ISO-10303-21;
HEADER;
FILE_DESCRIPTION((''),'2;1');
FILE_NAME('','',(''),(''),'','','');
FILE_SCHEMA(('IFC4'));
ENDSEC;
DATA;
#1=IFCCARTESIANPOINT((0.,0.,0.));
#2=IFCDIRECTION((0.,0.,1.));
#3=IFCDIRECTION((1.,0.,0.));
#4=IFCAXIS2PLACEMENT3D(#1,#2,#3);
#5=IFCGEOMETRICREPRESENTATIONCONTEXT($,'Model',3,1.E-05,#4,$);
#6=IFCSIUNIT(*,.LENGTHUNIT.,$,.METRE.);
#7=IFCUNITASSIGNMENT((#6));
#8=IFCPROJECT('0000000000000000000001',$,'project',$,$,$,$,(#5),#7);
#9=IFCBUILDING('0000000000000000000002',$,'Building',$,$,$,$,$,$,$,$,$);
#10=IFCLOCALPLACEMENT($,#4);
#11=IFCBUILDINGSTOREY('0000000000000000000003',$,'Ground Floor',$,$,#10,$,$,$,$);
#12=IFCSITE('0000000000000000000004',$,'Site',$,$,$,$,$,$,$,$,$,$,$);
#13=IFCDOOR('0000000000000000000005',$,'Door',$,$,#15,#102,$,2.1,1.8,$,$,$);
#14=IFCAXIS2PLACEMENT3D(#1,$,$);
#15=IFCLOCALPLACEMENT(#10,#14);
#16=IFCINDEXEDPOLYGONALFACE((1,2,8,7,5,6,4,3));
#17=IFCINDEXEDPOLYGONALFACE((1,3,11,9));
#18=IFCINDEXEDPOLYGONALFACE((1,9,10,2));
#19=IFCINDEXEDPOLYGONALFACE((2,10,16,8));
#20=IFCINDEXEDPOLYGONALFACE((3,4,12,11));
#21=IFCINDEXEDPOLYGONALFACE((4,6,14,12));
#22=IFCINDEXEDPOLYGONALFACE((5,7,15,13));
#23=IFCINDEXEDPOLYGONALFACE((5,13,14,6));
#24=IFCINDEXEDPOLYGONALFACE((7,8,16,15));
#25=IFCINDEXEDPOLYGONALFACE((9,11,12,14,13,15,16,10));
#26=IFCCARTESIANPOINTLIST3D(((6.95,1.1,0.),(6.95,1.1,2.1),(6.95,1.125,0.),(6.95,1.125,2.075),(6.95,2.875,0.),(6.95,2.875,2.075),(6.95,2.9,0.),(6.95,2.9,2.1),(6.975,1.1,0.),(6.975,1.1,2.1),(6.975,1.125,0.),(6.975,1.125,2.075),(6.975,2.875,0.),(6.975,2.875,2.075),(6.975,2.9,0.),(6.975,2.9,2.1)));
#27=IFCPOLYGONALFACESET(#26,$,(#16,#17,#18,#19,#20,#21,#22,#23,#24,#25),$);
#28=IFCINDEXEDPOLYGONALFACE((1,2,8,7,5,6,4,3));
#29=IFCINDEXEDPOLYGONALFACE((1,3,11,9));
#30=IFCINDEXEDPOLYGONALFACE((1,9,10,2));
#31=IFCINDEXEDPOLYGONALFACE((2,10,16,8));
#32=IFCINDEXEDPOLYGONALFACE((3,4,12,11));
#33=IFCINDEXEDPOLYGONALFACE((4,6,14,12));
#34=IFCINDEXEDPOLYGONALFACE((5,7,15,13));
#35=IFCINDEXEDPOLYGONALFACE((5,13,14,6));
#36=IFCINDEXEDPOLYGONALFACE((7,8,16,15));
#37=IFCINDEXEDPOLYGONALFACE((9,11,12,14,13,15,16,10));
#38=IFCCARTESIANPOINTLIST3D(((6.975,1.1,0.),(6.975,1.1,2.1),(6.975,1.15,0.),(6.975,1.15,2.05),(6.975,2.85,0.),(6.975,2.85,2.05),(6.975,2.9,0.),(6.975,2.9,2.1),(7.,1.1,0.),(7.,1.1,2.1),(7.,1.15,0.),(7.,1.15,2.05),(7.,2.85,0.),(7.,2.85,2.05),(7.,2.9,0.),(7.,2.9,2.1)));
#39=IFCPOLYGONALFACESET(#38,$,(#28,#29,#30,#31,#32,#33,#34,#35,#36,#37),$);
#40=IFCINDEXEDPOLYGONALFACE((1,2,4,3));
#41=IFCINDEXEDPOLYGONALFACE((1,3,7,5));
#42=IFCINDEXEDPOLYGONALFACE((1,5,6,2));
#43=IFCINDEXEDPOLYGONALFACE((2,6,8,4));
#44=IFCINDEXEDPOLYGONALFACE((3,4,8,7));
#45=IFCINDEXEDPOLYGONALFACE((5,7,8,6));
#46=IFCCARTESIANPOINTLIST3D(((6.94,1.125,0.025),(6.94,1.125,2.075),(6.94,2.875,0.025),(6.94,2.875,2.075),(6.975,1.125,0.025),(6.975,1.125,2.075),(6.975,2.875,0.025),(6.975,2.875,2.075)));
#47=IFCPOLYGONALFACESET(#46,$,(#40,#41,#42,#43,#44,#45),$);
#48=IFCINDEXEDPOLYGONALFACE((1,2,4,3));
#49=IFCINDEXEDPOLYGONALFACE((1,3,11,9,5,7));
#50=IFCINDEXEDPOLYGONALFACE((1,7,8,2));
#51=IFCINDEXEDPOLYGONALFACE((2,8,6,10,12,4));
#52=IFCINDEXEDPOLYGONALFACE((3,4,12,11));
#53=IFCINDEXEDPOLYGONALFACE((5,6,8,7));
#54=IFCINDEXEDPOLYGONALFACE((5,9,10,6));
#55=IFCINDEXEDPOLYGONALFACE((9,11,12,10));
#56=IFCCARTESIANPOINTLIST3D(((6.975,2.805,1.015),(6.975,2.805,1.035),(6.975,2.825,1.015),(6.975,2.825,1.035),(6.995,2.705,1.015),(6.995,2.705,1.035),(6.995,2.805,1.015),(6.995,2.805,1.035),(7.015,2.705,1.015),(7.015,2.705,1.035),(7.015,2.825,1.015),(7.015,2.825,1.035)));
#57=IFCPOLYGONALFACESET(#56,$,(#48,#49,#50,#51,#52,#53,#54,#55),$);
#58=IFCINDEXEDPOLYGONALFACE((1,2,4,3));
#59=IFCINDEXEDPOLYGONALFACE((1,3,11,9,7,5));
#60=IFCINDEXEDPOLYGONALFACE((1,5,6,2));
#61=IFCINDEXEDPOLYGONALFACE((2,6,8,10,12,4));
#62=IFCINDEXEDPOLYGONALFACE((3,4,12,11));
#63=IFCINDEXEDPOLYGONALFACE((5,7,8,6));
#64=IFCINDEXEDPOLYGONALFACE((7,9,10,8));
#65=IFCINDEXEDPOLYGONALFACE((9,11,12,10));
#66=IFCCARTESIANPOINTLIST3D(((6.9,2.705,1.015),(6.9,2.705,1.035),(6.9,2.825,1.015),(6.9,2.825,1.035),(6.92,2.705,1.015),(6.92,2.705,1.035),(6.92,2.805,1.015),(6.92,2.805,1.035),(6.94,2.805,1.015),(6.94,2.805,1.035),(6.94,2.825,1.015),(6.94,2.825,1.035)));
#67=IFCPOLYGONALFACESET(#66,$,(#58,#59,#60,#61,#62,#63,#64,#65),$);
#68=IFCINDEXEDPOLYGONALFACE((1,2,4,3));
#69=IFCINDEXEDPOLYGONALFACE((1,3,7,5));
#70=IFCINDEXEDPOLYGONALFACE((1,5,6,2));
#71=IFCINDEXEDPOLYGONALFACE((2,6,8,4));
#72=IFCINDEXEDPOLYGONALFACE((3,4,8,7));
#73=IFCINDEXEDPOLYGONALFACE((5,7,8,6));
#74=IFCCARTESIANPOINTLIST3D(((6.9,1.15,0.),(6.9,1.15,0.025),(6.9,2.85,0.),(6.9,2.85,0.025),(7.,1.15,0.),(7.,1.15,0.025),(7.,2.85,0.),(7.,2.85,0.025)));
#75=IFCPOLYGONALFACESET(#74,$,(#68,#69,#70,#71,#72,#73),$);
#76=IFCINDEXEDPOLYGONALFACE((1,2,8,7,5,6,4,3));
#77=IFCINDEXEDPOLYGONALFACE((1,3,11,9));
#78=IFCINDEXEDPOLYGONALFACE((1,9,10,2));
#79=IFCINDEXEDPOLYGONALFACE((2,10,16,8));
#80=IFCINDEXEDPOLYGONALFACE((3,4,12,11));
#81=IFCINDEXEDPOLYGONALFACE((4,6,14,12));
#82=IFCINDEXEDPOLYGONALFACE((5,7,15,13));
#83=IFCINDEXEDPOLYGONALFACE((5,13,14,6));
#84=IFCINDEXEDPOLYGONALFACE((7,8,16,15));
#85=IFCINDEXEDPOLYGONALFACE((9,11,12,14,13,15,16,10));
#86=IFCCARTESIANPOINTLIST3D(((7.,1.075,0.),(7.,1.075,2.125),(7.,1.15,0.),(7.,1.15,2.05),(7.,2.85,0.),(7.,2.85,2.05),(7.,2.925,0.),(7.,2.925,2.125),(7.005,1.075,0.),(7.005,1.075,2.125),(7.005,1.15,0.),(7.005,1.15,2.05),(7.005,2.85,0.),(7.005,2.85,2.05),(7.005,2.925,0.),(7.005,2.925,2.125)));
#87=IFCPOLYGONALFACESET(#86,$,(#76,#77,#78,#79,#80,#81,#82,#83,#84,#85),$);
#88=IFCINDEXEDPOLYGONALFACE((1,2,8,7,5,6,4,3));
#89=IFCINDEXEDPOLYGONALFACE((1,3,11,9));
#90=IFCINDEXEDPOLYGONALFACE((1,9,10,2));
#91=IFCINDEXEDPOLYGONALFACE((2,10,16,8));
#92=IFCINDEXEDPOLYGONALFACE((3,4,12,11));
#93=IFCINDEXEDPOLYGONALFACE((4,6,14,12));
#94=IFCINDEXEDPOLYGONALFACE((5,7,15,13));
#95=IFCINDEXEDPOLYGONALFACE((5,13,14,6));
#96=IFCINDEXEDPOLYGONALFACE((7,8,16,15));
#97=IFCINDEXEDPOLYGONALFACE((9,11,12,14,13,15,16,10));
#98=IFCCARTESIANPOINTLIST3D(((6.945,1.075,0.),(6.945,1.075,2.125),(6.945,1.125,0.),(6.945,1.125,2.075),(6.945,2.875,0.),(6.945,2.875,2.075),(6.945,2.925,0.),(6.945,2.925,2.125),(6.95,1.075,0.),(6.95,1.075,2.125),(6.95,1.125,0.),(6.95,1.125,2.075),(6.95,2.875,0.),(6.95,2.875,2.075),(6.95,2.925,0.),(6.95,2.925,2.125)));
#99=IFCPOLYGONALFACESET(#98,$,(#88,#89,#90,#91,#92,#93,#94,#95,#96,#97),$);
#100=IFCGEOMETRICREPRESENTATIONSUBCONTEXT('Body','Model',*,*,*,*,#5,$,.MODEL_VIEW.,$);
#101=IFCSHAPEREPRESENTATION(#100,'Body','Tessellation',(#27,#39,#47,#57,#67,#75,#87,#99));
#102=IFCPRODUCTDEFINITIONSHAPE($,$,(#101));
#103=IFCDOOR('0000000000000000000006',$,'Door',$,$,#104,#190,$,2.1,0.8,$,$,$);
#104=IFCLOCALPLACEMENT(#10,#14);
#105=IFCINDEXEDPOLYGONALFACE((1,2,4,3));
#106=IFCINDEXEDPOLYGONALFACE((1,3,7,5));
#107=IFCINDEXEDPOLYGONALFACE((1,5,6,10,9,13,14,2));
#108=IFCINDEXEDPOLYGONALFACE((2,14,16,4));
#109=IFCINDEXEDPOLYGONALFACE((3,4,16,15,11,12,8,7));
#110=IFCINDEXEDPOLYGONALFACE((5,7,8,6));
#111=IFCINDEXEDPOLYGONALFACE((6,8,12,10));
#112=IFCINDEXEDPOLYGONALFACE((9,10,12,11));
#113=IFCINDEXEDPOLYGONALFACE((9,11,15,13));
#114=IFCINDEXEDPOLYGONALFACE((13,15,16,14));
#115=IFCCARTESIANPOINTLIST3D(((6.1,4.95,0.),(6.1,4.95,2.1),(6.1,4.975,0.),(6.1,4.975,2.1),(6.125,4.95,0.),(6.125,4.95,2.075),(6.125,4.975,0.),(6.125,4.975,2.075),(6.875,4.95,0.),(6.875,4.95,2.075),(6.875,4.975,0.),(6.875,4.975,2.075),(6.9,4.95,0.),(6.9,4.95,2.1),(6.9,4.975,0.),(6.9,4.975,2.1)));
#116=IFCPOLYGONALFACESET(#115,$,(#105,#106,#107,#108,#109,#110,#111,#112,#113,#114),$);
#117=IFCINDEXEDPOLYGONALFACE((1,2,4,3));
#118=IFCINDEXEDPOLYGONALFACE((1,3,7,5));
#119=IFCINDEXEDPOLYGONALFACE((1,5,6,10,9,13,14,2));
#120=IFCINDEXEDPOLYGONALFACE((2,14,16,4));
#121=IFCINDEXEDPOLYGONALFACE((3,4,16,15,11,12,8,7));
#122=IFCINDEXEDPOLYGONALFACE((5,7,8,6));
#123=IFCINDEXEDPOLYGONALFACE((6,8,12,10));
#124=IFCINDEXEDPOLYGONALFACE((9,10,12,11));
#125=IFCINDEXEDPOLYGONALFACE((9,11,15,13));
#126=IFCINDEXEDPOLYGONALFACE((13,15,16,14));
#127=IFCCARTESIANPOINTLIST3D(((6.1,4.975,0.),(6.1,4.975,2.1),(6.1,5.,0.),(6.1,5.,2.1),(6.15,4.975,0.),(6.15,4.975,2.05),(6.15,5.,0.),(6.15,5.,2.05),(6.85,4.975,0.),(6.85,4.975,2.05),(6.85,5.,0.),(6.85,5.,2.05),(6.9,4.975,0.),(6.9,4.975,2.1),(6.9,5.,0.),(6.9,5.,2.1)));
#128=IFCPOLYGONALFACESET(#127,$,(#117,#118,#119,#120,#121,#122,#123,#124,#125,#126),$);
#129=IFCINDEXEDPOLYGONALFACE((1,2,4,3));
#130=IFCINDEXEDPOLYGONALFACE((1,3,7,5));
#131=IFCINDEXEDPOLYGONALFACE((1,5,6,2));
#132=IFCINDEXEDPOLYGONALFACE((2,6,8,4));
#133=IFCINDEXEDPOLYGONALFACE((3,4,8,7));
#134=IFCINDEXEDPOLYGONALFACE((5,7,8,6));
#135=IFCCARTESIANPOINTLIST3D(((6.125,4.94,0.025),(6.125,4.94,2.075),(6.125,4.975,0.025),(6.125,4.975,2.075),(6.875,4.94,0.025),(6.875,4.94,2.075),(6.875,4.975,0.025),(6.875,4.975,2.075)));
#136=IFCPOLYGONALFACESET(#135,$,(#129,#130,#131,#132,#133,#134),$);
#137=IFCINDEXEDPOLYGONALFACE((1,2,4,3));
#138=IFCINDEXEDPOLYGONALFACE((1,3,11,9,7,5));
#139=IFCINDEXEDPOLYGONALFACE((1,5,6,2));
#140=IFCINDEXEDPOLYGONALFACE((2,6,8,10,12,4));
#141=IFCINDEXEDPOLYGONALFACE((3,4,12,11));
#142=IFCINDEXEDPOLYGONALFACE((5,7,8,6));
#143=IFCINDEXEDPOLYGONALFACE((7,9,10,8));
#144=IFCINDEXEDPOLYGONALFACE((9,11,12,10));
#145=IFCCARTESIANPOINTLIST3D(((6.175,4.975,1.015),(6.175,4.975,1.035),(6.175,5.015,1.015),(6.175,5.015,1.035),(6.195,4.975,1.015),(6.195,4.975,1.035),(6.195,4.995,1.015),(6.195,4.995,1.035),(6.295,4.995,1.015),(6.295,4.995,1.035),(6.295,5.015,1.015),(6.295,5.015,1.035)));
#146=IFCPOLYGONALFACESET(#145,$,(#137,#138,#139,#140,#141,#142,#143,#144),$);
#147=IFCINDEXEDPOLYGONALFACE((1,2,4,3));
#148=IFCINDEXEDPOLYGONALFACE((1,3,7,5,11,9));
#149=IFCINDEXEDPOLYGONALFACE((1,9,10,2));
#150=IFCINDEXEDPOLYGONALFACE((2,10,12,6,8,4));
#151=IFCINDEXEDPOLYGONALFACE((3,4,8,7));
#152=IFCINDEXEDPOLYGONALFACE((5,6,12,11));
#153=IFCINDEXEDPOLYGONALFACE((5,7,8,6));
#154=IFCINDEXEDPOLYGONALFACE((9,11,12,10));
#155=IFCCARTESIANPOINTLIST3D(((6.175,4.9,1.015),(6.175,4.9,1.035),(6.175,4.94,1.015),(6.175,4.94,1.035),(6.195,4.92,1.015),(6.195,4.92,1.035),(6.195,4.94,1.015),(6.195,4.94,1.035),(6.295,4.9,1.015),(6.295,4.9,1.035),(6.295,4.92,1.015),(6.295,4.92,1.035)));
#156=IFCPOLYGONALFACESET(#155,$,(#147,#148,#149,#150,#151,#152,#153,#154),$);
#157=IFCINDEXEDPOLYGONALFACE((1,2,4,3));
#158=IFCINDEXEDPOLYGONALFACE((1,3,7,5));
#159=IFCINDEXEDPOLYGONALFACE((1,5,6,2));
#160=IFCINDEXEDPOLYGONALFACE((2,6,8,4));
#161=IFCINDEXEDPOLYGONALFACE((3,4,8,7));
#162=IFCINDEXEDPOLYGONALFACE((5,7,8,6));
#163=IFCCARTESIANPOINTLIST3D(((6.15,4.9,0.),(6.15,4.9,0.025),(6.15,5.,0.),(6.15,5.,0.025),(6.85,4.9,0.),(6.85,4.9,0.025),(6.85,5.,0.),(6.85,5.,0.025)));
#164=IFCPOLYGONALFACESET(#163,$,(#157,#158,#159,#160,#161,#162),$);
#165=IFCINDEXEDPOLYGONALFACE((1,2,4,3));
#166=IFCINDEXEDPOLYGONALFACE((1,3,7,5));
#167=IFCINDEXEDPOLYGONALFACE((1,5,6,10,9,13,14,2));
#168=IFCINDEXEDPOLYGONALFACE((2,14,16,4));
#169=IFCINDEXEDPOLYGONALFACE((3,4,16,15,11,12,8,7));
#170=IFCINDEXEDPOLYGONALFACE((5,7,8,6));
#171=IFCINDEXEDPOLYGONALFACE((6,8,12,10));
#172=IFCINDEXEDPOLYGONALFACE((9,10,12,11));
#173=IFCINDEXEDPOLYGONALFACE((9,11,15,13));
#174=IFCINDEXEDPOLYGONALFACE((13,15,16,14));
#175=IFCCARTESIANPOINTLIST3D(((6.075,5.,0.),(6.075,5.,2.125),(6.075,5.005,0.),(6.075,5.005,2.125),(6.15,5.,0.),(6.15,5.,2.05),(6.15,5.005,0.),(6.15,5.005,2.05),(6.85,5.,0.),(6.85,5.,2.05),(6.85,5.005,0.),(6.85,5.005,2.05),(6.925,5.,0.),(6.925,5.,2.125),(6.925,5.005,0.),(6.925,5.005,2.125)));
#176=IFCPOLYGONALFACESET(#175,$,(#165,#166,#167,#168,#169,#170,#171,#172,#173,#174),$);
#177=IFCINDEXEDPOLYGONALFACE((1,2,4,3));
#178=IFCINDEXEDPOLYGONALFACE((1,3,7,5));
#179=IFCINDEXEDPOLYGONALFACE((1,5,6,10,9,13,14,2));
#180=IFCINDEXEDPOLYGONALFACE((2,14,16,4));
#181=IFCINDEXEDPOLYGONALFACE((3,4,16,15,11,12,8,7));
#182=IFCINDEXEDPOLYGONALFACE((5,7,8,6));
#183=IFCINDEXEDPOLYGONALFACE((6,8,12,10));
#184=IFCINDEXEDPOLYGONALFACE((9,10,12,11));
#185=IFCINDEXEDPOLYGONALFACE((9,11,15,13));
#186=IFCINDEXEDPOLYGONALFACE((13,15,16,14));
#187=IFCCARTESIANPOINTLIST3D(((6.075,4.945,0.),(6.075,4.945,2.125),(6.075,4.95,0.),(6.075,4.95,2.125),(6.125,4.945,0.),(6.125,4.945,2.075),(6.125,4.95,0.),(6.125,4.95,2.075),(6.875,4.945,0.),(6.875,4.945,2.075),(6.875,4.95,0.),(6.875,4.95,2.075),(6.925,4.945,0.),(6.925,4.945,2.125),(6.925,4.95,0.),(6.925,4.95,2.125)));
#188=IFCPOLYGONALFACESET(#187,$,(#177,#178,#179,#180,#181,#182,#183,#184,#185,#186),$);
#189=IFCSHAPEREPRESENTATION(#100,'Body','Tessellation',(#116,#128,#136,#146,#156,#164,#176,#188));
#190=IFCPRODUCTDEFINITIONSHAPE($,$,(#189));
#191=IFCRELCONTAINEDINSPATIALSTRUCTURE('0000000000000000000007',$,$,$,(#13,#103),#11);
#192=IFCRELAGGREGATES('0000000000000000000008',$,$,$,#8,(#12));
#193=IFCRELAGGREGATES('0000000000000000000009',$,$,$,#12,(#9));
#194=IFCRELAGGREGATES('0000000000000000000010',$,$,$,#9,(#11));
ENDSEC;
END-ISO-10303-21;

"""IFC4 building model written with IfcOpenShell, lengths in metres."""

from ifc_helpers import new_model, si_unit, frame, origin_with_axes, place, context, subcontext, project, spatial, line, indexed_curve, outline, extrude, element, save


model = new_model("IFC4")

# Units and contexts
model_context = context("Model", 3, precision=1e-05, world=origin_with_axes())
body_context = subcontext(model_context, "Body", "Model", "MODEL_VIEW")
ifc_project = project(units=[si_unit("LENGTHUNIT", "METRE")], contexts=[model_context])

# Site, building, storey
site = spatial("IfcSite", under=ifc_project, Name="Site")
building = spatial("IfcBuilding", under=site, Name="Building")
storey_placement = place(None, origin_with_axes())
storey = spatial("IfcBuildingStorey", under=building, at=storey_placement, Name="Ground Floor")

# Doors
door_1_placement = place(storey_placement, frame((7.0, 1.1, 0.0), z_axis=(0.0, 0.0, 1.0), x_axis=(0.0, 1.0, 0.0)))
element("IfcDoor", 1, at=door_1_placement, inside=storey, Name="Door", OverallHeight=2.1, OverallWidth=1.8, context=body_context, shape_type="SweptSolid", body=[
    extrude(outline(indexed_curve([(0.0, 0.0), (0.0, 2.1), (1.8, 2.1), (1.8, 0.0), (1.775, 0.0), (1.775, 2.075), (0.025, 2.075), (0.025, 0.0)], segments=[line(1, 2, 3, 4, 5, 6, 7, 8, 1)])), frame((0.0, 0.025, 0.0), z_axis=(0.0, -1.0, 0.0), x_axis=(1.0, 0.0, 0.0)), (0.0, 0.0, -1.0), 0.025),
    extrude(outline(indexed_curve([(0.0, 0.0), (0.0, 2.1), (1.8, 2.1), (1.8, 0.0), (1.75, 0.0), (1.75, 2.05), (0.05, 2.05), (0.05, 0.0)], segments=[line(1, 2, 3, 4, 5, 6, 7, 8, 1)])), frame((0.0, 0.0, 0.0), z_axis=(0.0, -1.0, 0.0), x_axis=(1.0, 0.0, 0.0)), (0.0, 0.0, -1.0), 0.025),
    extrude(outline(indexed_curve([(0.0, 0.0), (1.75, 0.0), (1.75, 0.035), (0.0, 0.035)], segments=[line(1, 2, 3, 4, 1)])), frame((0.025, 0.025, 0.025), z_axis=(0.0, 0.0, 1.0), x_axis=(1.0, 0.0, 0.0)), (0.0, 0.0, 1.0), 2.05),
    extrude(outline(indexed_curve([(0.0, 0.0), (0.0, -0.04), (-0.12, -0.04), (-0.12, -0.02), (-0.02, -0.02), (-0.02, 0.0)], segments=[line(1, 2, 3, 4, 5, 6, 1)])), frame((1.725, 0.025, 1.015), z_axis=(0.0, 0.0, 1.0), x_axis=(1.0, 0.0, 0.0)), (0.0, 0.0, 1.0), 0.02),
    extrude(outline(indexed_curve([(0.0, 0.0), (0.0, 0.04), (-0.12, 0.04), (-0.12, 0.02), (-0.02, 0.02), (-0.02, 0.0)], segments=[line(1, 2, 3, 4, 5, 6, 1)])), frame((1.725, 0.06, 1.015), z_axis=(0.0, 0.0, 1.0), x_axis=(1.0, 0.0, 0.0)), (0.0, 0.0, 1.0), 0.02),
    extrude(outline(indexed_curve([(0.0, 0.0), (1.7, 0.0), (1.7, 0.1), (0.0, 0.1)], segments=[line(1, 2, 3, 4, 1)])), frame((0.05, 0.0, 0.0), z_axis=(0.0, 0.0, 1.0), x_axis=(1.0, 0.0, 0.0)), (0.0, 0.0, 1.0), 0.025),
    extrude(outline(indexed_curve([(0.0, 0.0), (0.0, 2.125), (1.85, 2.125), (1.85, 0.0), (1.775, 0.0), (1.775, 2.05), (0.075, 2.05), (0.075, 0.0)], segments=[line(1, 2, 3, 4, 5, 6, 7, 8, 1)])), frame((-0.025, -0.005, 0.0), z_axis=(0.0, -1.0, 0.0), x_axis=(1.0, 0.0, 0.0)), (0.0, 0.0, -1.0), 0.005),
    extrude(outline(indexed_curve([(0.0, 0.0), (0.0, 2.125), (1.85, 2.125), (1.85, 0.0), (1.8, 0.0), (1.8, 2.075), (0.05, 2.075), (0.05, 0.0)], segments=[line(1, 2, 3, 4, 5, 6, 7, 8, 1)])), frame((-0.025, 0.05, 0.0), z_axis=(0.0, -1.0, 0.0), x_axis=(1.0, 0.0, 0.0)), (0.0, 0.0, -1.0), 0.005),
])
door_2_placement = place(storey_placement, frame((6.9, 5.0, 0.0), z_axis=(0.0, 0.0, 1.0), x_axis=(-1.0, 0.0, 0.0)))
element("IfcDoor", 2, at=door_2_placement, inside=storey, Name="Door", OverallHeight=2.1, OverallWidth=0.8, context=body_context, shape_type="SweptSolid", body=[
    extrude(outline(indexed_curve([(0.0, 0.0), (0.0, 2.1), (0.8, 2.1), (0.8, 0.0), (0.775, 0.0), (0.775, 2.075), (0.025, 2.075), (0.025, 0.0)], segments=[line(1, 2, 3, 4, 5, 6, 7, 8, 1)])), frame((0.0, 0.025, 0.0), z_axis=(0.0, -1.0, 0.0), x_axis=(1.0, 0.0, 0.0)), (0.0, 0.0, -1.0), 0.025),
    extrude(outline(indexed_curve([(0.0, 0.0), (0.0, 2.1), (0.8, 2.1), (0.8, 0.0), (0.75, 0.0), (0.75, 2.05), (0.05, 2.05), (0.05, 0.0)], segments=[line(1, 2, 3, 4, 5, 6, 7, 8, 1)])), frame((0.0, 0.0, 0.0), z_axis=(0.0, -1.0, 0.0), x_axis=(1.0, 0.0, 0.0)), (0.0, 0.0, -1.0), 0.025),
    extrude(outline(indexed_curve([(0.0, 0.0), (0.75, 0.0), (0.75, 0.035), (0.0, 0.035)], segments=[line(1, 2, 3, 4, 1)])), frame((0.025, 0.025, 0.025), z_axis=(0.0, 0.0, 1.0), x_axis=(1.0, 0.0, 0.0)), (0.0, 0.0, 1.0), 2.05),
    extrude(outline(indexed_curve([(0.0, 0.0), (0.0, -0.04), (-0.12, -0.04), (-0.12, -0.02), (-0.02, -0.02), (-0.02, 0.0)], segments=[line(1, 2, 3, 4, 5, 6, 1)])), frame((0.725, 0.025, 1.015), z_axis=(0.0, 0.0, 1.0), x_axis=(1.0, 0.0, 0.0)), (0.0, 0.0, 1.0), 0.02),
    extrude(outline(indexed_curve([(0.0, 0.0), (0.0, 0.04), (-0.12, 0.04), (-0.12, 0.02), (-0.02, 0.02), (-0.02, 0.0)], segments=[line(1, 2, 3, 4, 5, 6, 1)])), frame((0.725, 0.06, 1.015), z_axis=(0.0, 0.0, 1.0), x_axis=(1.0, 0.0, 0.0)), (0.0, 0.0, 1.0), 0.02),
    extrude(outline(indexed_curve([(0.0, 0.0), (0.7, 0.0), (0.7, 0.1), (0.0, 0.1)], segments=[line(1, 2, 3, 4, 1)])), frame((0.05, 0.0, 0.0), z_axis=(0.0, 0.0, 1.0), x_axis=(1.0, 0.0, 0.0)), (0.0, 0.0, 1.0), 0.025),
    extrude(outline(indexed_curve([(0.0, 0.0), (0.0, 2.125), (0.85, 2.125), (0.85, 0.0), (0.775, 0.0), (0.775, 2.05), (0.075, 2.05), (0.075, 0.0)], segments=[line(1, 2, 3, 4, 5, 6, 7, 8, 1)])), frame((-0.025, -0.005, 0.0), z_axis=(0.0, -1.0, 0.0), x_axis=(1.0, 0.0, 0.0)), (0.0, 0.0, -1.0), 0.005),
    extrude(outline(indexed_curve([(0.0, 0.0), (0.0, 2.125), (0.85, 2.125), (0.85, 0.0), (0.8, 0.0), (0.8, 2.075), (0.05, 2.075), (0.05, 0.0)], segments=[line(1, 2, 3, 4, 5, 6, 7, 8, 1)])), frame((-0.025, 0.05, 0.0), z_axis=(0.0, -1.0, 0.0), x_axis=(1.0, 0.0, 0.0)), (0.0, 0.0, -1.0), 0.005),
])

save(model, "model.ifc")
